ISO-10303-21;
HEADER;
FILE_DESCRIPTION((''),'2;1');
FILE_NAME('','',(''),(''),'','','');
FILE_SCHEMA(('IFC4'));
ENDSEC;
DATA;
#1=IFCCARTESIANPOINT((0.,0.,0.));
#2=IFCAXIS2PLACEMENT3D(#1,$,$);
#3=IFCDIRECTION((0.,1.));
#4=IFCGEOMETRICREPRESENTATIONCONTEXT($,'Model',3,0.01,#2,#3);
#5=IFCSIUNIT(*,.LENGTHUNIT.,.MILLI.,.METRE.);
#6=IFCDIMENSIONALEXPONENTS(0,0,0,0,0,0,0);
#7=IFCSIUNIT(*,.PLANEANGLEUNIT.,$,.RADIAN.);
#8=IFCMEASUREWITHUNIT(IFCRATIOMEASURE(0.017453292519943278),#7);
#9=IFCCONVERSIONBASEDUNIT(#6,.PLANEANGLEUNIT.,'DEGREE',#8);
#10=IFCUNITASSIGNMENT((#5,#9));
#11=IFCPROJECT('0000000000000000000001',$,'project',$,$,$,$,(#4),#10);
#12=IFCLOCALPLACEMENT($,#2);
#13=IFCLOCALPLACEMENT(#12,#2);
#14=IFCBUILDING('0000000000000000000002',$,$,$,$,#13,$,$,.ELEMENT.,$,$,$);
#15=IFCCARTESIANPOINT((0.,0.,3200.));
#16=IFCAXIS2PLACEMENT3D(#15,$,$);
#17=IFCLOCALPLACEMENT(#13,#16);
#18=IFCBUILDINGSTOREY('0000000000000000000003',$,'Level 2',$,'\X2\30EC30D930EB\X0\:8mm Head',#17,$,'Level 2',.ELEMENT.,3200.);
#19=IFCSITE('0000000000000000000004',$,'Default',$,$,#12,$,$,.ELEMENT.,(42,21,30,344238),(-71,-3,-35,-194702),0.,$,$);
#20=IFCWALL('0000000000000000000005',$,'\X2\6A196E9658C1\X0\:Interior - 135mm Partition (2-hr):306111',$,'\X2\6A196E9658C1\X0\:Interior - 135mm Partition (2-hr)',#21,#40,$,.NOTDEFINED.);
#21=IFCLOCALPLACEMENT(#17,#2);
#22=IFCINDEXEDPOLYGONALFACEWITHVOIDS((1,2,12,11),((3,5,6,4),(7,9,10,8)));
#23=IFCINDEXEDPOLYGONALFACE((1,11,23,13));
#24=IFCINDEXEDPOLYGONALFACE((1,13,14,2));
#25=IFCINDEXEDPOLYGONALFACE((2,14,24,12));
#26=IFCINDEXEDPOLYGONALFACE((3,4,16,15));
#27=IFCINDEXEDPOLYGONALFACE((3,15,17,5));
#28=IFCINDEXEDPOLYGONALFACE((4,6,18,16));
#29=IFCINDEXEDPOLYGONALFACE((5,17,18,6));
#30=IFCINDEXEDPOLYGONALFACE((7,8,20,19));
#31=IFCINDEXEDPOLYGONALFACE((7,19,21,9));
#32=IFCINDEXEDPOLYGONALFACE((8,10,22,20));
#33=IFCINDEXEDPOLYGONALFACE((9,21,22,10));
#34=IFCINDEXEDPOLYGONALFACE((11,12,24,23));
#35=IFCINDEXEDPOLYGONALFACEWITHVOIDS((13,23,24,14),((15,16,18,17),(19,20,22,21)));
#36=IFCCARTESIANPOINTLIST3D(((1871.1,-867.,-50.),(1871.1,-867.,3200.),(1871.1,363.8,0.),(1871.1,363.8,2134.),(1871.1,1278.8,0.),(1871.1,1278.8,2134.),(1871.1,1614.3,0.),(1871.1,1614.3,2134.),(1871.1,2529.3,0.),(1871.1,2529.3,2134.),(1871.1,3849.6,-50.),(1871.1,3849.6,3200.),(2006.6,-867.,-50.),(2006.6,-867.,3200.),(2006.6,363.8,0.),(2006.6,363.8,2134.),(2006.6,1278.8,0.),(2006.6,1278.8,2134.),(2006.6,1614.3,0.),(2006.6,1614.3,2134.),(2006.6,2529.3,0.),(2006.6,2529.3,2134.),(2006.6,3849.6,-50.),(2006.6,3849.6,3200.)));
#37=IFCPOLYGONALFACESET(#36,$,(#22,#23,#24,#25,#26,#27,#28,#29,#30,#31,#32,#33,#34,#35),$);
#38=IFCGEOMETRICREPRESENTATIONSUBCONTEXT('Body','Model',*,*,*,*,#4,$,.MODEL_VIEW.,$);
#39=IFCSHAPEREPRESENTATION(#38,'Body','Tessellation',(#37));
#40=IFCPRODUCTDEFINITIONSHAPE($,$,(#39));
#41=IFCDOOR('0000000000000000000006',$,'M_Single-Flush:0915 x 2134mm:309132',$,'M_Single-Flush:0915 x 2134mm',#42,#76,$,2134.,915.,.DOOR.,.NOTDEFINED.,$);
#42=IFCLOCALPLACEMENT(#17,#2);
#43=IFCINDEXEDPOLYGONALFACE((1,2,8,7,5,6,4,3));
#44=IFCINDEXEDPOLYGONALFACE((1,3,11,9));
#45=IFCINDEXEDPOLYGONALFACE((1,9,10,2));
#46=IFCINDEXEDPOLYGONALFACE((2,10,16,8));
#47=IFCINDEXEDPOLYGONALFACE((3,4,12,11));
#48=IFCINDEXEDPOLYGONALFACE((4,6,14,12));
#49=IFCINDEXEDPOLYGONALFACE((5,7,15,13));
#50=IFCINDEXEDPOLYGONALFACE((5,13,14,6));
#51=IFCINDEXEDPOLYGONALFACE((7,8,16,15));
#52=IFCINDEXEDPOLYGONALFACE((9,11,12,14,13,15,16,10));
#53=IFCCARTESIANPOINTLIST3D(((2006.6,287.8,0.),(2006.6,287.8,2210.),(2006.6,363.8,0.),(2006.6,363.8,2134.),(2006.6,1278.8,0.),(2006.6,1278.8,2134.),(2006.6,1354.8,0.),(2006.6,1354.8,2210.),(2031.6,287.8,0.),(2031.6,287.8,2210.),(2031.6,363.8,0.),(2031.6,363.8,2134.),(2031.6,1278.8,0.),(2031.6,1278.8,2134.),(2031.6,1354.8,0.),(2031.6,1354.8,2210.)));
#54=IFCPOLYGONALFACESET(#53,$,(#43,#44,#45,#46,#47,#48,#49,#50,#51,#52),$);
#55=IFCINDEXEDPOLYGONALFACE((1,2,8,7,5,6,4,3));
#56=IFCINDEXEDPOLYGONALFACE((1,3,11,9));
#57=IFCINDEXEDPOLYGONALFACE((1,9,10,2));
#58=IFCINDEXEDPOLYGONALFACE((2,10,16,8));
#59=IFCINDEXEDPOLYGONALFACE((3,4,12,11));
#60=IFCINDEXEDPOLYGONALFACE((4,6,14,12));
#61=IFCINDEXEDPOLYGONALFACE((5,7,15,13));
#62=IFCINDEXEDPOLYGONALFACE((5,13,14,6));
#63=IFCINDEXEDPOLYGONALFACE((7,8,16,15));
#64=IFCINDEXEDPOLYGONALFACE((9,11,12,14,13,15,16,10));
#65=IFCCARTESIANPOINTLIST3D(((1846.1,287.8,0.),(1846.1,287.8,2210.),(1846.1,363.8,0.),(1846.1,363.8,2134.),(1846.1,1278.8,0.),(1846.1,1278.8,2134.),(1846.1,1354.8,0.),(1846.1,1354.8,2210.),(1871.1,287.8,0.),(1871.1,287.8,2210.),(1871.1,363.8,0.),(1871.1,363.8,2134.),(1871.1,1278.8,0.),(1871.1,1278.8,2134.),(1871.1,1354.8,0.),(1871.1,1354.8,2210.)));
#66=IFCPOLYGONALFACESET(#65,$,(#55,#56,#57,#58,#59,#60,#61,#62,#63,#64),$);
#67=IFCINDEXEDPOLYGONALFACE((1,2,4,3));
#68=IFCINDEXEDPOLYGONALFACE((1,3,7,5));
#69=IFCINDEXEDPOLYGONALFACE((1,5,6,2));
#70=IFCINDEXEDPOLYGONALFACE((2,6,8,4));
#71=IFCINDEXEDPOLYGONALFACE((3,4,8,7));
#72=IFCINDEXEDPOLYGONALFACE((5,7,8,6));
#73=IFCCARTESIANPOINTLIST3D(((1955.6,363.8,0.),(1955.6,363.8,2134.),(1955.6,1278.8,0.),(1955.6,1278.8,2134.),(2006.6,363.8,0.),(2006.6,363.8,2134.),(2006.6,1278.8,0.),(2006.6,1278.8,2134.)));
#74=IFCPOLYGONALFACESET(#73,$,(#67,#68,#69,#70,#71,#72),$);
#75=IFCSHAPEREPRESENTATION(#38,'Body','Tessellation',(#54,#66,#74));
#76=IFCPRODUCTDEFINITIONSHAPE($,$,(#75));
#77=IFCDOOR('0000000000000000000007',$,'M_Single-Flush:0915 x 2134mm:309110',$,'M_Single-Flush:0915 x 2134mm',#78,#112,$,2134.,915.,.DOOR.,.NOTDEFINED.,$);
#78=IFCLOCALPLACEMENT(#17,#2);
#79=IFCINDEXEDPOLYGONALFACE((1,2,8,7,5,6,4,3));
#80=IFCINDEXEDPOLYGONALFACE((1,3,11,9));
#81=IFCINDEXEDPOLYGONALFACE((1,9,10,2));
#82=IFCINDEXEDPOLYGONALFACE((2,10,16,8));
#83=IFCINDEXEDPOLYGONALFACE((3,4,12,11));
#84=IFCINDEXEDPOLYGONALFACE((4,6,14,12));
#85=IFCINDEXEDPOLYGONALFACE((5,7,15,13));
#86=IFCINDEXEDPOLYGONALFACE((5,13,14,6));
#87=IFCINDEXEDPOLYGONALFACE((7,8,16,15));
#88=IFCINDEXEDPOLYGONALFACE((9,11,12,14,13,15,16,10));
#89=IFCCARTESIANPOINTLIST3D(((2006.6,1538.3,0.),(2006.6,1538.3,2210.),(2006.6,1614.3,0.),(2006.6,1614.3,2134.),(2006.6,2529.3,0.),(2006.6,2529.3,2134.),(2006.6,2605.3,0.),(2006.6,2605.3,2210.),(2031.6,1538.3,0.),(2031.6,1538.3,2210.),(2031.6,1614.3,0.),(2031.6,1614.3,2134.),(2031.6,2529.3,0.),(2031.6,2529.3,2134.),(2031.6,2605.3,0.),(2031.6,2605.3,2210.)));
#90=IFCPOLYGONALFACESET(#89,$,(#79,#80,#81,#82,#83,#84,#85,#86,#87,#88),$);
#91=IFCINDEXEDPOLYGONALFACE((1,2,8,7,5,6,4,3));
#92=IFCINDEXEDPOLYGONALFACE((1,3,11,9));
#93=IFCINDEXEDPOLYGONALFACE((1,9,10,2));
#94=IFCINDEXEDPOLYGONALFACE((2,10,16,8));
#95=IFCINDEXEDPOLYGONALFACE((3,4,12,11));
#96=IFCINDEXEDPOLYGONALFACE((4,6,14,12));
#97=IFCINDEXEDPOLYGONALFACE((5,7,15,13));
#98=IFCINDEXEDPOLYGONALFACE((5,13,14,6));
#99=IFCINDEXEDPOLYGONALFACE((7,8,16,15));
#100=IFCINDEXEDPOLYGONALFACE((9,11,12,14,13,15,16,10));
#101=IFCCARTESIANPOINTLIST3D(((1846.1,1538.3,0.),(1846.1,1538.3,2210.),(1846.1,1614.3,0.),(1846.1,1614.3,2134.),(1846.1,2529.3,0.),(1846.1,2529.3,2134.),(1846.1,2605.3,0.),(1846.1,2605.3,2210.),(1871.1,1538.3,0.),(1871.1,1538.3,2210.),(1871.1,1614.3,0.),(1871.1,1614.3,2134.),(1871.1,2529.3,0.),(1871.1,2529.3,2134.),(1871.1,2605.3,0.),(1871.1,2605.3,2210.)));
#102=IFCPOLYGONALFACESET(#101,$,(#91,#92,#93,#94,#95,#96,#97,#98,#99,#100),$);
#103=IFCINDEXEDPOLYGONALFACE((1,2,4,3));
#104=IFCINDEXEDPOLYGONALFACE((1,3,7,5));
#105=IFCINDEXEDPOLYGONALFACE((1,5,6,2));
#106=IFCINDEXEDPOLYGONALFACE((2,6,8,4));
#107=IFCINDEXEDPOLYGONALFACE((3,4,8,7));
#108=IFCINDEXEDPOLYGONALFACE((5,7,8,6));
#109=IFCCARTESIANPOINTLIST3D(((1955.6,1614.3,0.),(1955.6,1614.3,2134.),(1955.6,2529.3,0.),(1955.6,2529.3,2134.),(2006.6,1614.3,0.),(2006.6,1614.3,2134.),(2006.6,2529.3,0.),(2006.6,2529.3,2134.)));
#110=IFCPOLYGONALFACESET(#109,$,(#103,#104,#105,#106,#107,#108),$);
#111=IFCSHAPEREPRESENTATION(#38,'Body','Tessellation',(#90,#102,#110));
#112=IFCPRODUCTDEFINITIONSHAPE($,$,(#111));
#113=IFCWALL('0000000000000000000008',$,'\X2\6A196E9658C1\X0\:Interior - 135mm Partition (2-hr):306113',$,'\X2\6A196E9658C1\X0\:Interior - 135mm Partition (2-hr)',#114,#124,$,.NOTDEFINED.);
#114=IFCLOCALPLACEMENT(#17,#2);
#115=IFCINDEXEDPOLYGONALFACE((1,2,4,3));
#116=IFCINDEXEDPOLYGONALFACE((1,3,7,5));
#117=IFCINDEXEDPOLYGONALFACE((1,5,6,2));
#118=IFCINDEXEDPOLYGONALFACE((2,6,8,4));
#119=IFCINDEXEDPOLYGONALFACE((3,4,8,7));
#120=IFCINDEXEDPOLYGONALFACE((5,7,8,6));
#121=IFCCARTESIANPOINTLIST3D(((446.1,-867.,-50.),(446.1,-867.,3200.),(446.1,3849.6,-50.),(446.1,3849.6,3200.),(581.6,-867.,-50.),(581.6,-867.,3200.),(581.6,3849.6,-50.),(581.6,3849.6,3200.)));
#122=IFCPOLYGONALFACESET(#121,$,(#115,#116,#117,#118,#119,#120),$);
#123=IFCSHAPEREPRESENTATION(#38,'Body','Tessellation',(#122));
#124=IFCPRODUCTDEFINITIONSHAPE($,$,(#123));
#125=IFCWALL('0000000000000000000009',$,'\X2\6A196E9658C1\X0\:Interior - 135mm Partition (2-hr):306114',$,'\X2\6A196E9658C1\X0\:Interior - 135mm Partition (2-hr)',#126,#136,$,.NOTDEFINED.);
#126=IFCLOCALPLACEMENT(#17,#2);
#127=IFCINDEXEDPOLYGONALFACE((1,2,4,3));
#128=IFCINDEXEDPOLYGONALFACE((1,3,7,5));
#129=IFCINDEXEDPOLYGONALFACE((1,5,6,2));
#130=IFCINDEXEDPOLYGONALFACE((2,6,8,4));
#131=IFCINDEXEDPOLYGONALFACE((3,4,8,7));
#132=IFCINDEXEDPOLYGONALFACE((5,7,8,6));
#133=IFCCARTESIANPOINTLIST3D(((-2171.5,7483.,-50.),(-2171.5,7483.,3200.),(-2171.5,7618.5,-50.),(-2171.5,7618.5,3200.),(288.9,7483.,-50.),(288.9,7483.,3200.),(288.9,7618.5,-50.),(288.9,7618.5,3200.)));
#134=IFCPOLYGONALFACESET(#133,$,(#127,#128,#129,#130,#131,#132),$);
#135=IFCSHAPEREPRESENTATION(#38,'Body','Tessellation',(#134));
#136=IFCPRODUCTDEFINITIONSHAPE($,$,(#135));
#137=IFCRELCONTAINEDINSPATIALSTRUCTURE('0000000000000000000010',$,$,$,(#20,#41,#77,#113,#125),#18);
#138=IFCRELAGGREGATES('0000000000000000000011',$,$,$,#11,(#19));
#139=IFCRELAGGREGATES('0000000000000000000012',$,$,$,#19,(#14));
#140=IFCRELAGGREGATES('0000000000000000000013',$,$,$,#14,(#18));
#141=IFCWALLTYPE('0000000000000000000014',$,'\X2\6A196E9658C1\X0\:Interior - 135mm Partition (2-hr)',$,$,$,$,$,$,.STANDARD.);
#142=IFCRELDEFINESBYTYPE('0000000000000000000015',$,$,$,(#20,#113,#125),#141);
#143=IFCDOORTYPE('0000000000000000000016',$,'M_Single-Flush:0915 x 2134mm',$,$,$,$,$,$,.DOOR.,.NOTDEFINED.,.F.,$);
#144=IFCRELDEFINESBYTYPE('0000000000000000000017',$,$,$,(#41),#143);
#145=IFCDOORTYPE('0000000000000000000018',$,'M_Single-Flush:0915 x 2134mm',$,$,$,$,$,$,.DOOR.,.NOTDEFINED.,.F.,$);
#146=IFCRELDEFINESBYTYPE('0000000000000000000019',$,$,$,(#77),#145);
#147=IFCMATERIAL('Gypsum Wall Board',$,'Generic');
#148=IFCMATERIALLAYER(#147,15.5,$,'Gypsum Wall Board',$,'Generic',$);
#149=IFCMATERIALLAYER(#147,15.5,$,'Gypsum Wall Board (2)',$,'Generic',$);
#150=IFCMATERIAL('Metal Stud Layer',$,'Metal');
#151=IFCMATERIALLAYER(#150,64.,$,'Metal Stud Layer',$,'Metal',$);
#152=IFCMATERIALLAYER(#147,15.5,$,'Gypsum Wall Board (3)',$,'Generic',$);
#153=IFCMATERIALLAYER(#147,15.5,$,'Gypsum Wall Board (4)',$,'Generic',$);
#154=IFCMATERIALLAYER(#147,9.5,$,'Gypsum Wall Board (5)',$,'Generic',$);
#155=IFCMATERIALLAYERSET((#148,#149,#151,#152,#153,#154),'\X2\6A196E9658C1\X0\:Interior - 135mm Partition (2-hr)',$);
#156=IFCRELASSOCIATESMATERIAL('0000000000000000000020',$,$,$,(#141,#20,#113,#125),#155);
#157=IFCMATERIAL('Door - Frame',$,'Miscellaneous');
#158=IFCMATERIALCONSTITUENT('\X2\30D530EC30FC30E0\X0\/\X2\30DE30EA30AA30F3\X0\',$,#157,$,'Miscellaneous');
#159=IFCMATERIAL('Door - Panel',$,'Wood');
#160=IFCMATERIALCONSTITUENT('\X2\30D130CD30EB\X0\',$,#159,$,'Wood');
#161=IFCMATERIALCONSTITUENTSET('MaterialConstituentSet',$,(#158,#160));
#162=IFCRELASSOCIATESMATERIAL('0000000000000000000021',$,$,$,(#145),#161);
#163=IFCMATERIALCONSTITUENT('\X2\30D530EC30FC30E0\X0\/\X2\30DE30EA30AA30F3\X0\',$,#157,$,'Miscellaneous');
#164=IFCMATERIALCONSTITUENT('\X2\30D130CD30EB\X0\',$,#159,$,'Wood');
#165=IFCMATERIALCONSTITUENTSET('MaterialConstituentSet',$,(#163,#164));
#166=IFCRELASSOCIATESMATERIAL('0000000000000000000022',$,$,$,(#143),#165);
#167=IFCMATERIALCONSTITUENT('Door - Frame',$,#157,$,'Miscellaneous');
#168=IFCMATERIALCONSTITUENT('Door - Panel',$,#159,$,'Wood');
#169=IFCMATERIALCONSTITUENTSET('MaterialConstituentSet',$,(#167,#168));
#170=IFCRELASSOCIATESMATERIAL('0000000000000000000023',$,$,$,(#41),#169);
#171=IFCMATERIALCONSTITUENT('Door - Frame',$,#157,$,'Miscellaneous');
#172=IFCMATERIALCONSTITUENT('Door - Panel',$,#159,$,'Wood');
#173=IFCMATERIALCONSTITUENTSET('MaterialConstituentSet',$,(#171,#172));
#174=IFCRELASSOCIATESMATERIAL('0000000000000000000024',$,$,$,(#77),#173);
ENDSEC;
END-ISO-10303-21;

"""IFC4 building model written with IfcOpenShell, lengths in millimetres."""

from ifc_helpers import new_model, entity, si_unit, converted_unit, direction, frame, frame_2d, origin, place, context, subcontext, project, spatial, polyline, rectangle, outline, extrude, source, transform, mapped, material, layer, layer_set, layer_usage, constituent, constituent_set, type_object, type_shapes, element, fill, save


model = new_model("IFC4")

# Units and contexts
model_context = context("Model", 3, precision=0.01, world=origin(), true_north=direction((0.0, 1.0)))
body_context = subcontext(model_context, "Body", "Model", "MODEL_VIEW")
ifc_project = project(units=[si_unit("LENGTHUNIT", "METRE", prefix="MILLI"), converted_unit("PLANEANGLEUNIT", "DEGREE", entity("IfcRatioMeasure", 0.017453292519943278), si_unit("PLANEANGLEUNIT", "RADIAN"), dimensions=[0, 0, 0, 0, 0, 0, 0])], contexts=[model_context])

# Site, building, storey
site_placement = place(None, origin())
site = spatial("IfcSite", under=ifc_project, at=site_placement, Name="Default", CompositionType="ELEMENT", RefLatitude=(42, 21, 30, 344238), RefLongitude=(-71, -3, -35, -194702), RefElevation=0.0)
building_placement = place(site_placement, origin())
building = spatial("IfcBuilding", under=site, at=building_placement, CompositionType="ELEMENT")
storey_placement = place(building_placement, frame((0.0, 0.0, 3200.0)))
storey = spatial("IfcBuildingStorey", under=building, at=storey_placement, Name="Level 2", ObjectType="レベル:8mm Head", LongName="Level 2", CompositionType="ELEMENT", Elevation=3200.0)

# Wall, openings, doors
ifc_material_1 = material(Name="Gypsum Wall Board", Category="Generic")
ifc_layer_1 = layer(ifc_material_1, 15.5, Name="Gypsum Wall Board", Category="Generic")
ifc_layer_2 = layer(ifc_material_1, 15.5, Name="Gypsum Wall Board (2)", Category="Generic")
ifc_material_2 = material(Name="Metal Stud Layer", Category="Metal")
ifc_layer_3 = layer(ifc_material_2, 64.0, Name="Metal Stud Layer", Category="Metal")
ifc_layer_4 = layer(ifc_material_1, 15.5, Name="Gypsum Wall Board (3)", Category="Generic")
ifc_layer_5 = layer(ifc_material_1, 15.5, Name="Gypsum Wall Board (4)", Category="Generic")
ifc_layer_6 = layer(ifc_material_1, 9.5, Name="Gypsum Wall Board (5)", Category="Generic")
ifc_layer_set_1 = layer_set([ifc_layer_1, ifc_layer_2, ifc_layer_3, ifc_layer_4, ifc_layer_5, ifc_layer_6], Name="標準壁:Interior - 135mm Partition (2-hr)")
wall_type = type_object("IfcWallType", Name="標準壁:Interior - 135mm Partition (2-hr)", PredefinedType="STANDARD", material=ifc_layer_set_1)
ifc_material_3 = material(Name="Door - Frame", Category="Miscellaneous")
ifc_material_4 = material(Name="Door - Panel", Category="Wood")
ifc_constituent_1 = constituent(ifc_material_3, Name="フレーム/マリオン", Category="Miscellaneous")
ifc_constituent_2 = constituent(ifc_material_4, Name="パネル", Category="Wood")
ifc_constituent_set_1 = constituent_set(constituents=[ifc_constituent_1, ifc_constituent_2], Name="MaterialConstituentSet")
door_type_1 = type_object("IfcDoorType", Name="M_Single-Flush:0915 x 2134mm", OperationType="NOTDEFINED", ParameterTakesPrecedence=False, PredefinedType="DOOR", material=ifc_constituent_set_1)
shared_shape_1 = source(origin(), body_context, "Body", "SweptSolid", [
    extrude(outline(polyline([(-533.5, -1124.0), (533.5, -1124.0), (533.5, 1086.0), (457.5, 1086.0), (457.5, -1048.0), (-457.5, -1048.0), (-457.5, 1086.0), (-533.5, 1086.0), (-533.5, -1124.0)])), frame((457.5, 135.5, 1086.0), z_axis=(0.0, 1.0, 0.0), x_axis=(1.0, 0.0, 0.0)), (0.0, 0.0, 1.0), 25.0),
    extrude(outline(polyline([(-1124.0, -533.5), (1086.0, -533.5), (1086.0, -457.5), (-1048.0, -457.5), (-1048.0, 457.5), (1086.0, 457.5), (1086.0, 533.5), (-1124.0, 533.5), (-1124.0, -533.5)])), frame((457.5, -25.0, 1086.0), z_axis=(0.0, 1.0, 0.0), x_axis=(0.0, 0.0, -1.0)), (0.0, 0.0, 1.0), 25.0),
    extrude(rectangle(XDim=51.0, YDim=915.0, at=frame_2d((0.0, 0.0), x_axis=(1.0, 0.0))), frame((457.5, 110.0, 0.0), z_axis=(0.0, 0.0, 1.0), x_axis=(0.0, 1.0, 0.0)), (0.0, 0.0, 1.0), 2134.0),
])
type_shapes(door_type_1, [shared_shape_1])
ifc_layer_usage_1 = layer_usage(ifc_layer_set_1, "AXIS2", "NEGATIVE", 67.8)
wall_1_placement = place(storey_placement, frame((1938.9, 3849.6, -50.0), z_axis=(0.0, 0.0, 1.0), x_axis=(0.0, -1.0, 0.0)))
wall_1 = element("IfcWall", 1, at=wall_1_placement, inside=storey, type_object=wall_type, material=ifc_layer_usage_1, Name="標準壁:Interior - 135mm Partition (2-hr):306111", ObjectType="標準壁:Interior - 135mm Partition (2-hr)", PredefinedType="NOTDEFINED", context=body_context, shape_type="SweptSolid", body=[
    extrude(rectangle(XDim=4716.6, YDim=135.5, at=frame_2d((2358.3, 0.0), x_axis=(-1.0, 0.0))), origin(), (0.0, 0.0, 1.0), 3250.0),
])
opening_1_placement = place(wall_1_placement, frame((1320.3, -67.8, 50.0)))
opening_1 = element("IfcOpeningElement", 2, at=opening_1_placement, cuts=wall_1, PredefinedType="OPENING", context=body_context, shape_type="SweptSolid", body=[
    extrude(rectangle(XDim=915.0, YDim=2134.0, at=frame_2d((1067.0, 457.5), x_axis=(0.0, 1.0))), frame((0.0, 0.0, 0.0), z_axis=(0.0, 1.0, 0.0), x_axis=(0.0, 0.0, 1.0)), (0.0, 0.0, 1.0), 135.5),
])
opening_2_placement = place(wall_1_placement, frame((2570.8, -67.8, 50.0)))
opening_2 = element("IfcOpeningElement", 3, at=opening_2_placement, cuts=wall_1, PredefinedType="OPENING", context=body_context, shape_type="SweptSolid", body=[
    extrude(rectangle(XDim=915.0, YDim=2134.0, at=frame_2d((1067.0, 457.5), x_axis=(0.0, -1.0))), frame((0.0, 0.0, 0.0), z_axis=(0.0, 1.0, 0.0), x_axis=(0.0, 0.0, 1.0)), (0.0, 0.0, 1.0), 135.5),
])
ifc_constituent_3 = constituent(ifc_material_3, Name="Door - Frame", Category="Miscellaneous")
ifc_constituent_4 = constituent(ifc_material_4, Name="Door - Panel", Category="Wood")
ifc_constituent_set_2 = constituent_set(constituents=[ifc_constituent_3, ifc_constituent_4], Name="MaterialConstituentSet")
ifc_constituent_5 = constituent(ifc_material_3, Name="フレーム/マリオン", Category="Miscellaneous")
ifc_constituent_6 = constituent(ifc_material_4, Name="パネル", Category="Wood")
ifc_constituent_set_3 = constituent_set(constituents=[ifc_constituent_5, ifc_constituent_6], Name="MaterialConstituentSet")
door_type_2 = type_object("IfcDoorType", Name="M_Single-Flush:0915 x 2134mm", OperationType="NOTDEFINED", ParameterTakesPrecedence=False, PredefinedType="DOOR", material=ifc_constituent_set_3)
shared_shape_2 = source(origin(), body_context, "Body", "SweptSolid", [
    extrude(outline(polyline([(-533.5, -1124.0), (533.5, -1124.0), (533.5, 1086.0), (457.5, 1086.0), (457.5, -1048.0), (-457.5, -1048.0), (-457.5, 1086.0), (-533.5, 1086.0), (-533.5, -1124.0)])), frame((457.5, 160.5, 1086.0), z_axis=(0.0, -1.0, 0.0), x_axis=(-1.0, 0.0, 0.0)), (0.0, 0.0, 1.0), 25.0),
    extrude(outline(polyline([(-1124.0, -533.5), (1086.0, -533.5), (1086.0, -457.5), (-1048.0, -457.5), (-1048.0, 457.5), (1086.0, 457.5), (1086.0, 533.5), (-1124.0, 533.5), (-1124.0, -533.5)])), frame((457.5, 0.0, 1086.0), z_axis=(0.0, -1.0, 0.0), x_axis=(0.0, 0.0, -1.0)), (0.0, 0.0, 1.0), 25.0),
    extrude(rectangle(XDim=915.0, YDim=51.0, at=frame_2d((0.0, 0.0), x_axis=(1.0, 0.0))), frame((457.5, 110.0, 0.0)), (0.0, 0.0, 1.0), 2134.0),
])
type_shapes(door_type_2, [shared_shape_2])
door_1_placement = place(opening_2_placement, origin())
door_1 = element("IfcDoor", 4, at=door_1_placement, inside=storey, type_object=door_type_2, material=ifc_constituent_set_2, Name="M_Single-Flush:0915 x 2134mm:309132", ObjectType="M_Single-Flush:0915 x 2134mm", OperationType="NOTDEFINED", OverallHeight=2134.0, OverallWidth=915.0, PredefinedType="DOOR", context=body_context, shape_type="MappedRepresentation", body=[
    mapped(shared_shape_2, transform((0.0, 0.0, 0.0), scale=1.0)),
])
fill(opening_2, door_1)
ifc_constituent_7 = constituent(ifc_material_3, Name="Door - Frame", Category="Miscellaneous")
ifc_constituent_8 = constituent(ifc_material_4, Name="Door - Panel", Category="Wood")
ifc_constituent_set_4 = constituent_set(constituents=[ifc_constituent_7, ifc_constituent_8], Name="MaterialConstituentSet")
door_2_placement = place(opening_1_placement, origin())
door_2 = element("IfcDoor", 5, at=door_2_placement, inside=storey, type_object=door_type_1, material=ifc_constituent_set_4, Name="M_Single-Flush:0915 x 2134mm:309110", ObjectType="M_Single-Flush:0915 x 2134mm", OperationType="NOTDEFINED", OverallHeight=2134.0, OverallWidth=915.0, PredefinedType="DOOR", context=body_context, shape_type="MappedRepresentation", body=[
    mapped(shared_shape_1, transform((0.0, 0.0, 0.0), scale=1.0)),
])
fill(opening_1, door_2)

# Walls
ifc_layer_usage_2 = layer_usage(ifc_layer_set_1, "AXIS2", "NEGATIVE", 67.8)
wall_2_placement = place(storey_placement, frame((513.9, 3849.6, -50.0), z_axis=(0.0, 0.0, 1.0), x_axis=(0.0, -1.0, 0.0)))
element("IfcWall", 6, at=wall_2_placement, inside=storey, type_object=wall_type, material=ifc_layer_usage_2, Name="標準壁:Interior - 135mm Partition (2-hr):306113", ObjectType="標準壁:Interior - 135mm Partition (2-hr)", PredefinedType="NOTDEFINED", context=body_context, shape_type="SweptSolid", body=[
    extrude(rectangle(XDim=4716.6, YDim=135.5, at=frame_2d((2358.3, 0.0), x_axis=(-1.0, 0.0))), origin(), (0.0, 0.0, 1.0), 3250.0),
])
ifc_layer_usage_3 = layer_usage(ifc_layer_set_1, "AXIS2", "NEGATIVE", 67.8)
wall_3_placement = place(storey_placement, frame((288.9, 7550.8, -50.0), z_axis=(0.0, 0.0, 1.0), x_axis=(-1.0, 0.0, 0.0)))
element("IfcWall", 7, at=wall_3_placement, inside=storey, type_object=wall_type, material=ifc_layer_usage_3, Name="標準壁:Interior - 135mm Partition (2-hr):306114", ObjectType="標準壁:Interior - 135mm Partition (2-hr)", PredefinedType="NOTDEFINED", context=body_context, shape_type="SweptSolid", body=[
    extrude(rectangle(XDim=2460.4, YDim=135.5, at=frame_2d((1230.2, 0.0), x_axis=(-1.0, 0.0))), origin(), (0.0, 0.0, 1.0), 3250.0),
])

save(model, "model.ifc")
